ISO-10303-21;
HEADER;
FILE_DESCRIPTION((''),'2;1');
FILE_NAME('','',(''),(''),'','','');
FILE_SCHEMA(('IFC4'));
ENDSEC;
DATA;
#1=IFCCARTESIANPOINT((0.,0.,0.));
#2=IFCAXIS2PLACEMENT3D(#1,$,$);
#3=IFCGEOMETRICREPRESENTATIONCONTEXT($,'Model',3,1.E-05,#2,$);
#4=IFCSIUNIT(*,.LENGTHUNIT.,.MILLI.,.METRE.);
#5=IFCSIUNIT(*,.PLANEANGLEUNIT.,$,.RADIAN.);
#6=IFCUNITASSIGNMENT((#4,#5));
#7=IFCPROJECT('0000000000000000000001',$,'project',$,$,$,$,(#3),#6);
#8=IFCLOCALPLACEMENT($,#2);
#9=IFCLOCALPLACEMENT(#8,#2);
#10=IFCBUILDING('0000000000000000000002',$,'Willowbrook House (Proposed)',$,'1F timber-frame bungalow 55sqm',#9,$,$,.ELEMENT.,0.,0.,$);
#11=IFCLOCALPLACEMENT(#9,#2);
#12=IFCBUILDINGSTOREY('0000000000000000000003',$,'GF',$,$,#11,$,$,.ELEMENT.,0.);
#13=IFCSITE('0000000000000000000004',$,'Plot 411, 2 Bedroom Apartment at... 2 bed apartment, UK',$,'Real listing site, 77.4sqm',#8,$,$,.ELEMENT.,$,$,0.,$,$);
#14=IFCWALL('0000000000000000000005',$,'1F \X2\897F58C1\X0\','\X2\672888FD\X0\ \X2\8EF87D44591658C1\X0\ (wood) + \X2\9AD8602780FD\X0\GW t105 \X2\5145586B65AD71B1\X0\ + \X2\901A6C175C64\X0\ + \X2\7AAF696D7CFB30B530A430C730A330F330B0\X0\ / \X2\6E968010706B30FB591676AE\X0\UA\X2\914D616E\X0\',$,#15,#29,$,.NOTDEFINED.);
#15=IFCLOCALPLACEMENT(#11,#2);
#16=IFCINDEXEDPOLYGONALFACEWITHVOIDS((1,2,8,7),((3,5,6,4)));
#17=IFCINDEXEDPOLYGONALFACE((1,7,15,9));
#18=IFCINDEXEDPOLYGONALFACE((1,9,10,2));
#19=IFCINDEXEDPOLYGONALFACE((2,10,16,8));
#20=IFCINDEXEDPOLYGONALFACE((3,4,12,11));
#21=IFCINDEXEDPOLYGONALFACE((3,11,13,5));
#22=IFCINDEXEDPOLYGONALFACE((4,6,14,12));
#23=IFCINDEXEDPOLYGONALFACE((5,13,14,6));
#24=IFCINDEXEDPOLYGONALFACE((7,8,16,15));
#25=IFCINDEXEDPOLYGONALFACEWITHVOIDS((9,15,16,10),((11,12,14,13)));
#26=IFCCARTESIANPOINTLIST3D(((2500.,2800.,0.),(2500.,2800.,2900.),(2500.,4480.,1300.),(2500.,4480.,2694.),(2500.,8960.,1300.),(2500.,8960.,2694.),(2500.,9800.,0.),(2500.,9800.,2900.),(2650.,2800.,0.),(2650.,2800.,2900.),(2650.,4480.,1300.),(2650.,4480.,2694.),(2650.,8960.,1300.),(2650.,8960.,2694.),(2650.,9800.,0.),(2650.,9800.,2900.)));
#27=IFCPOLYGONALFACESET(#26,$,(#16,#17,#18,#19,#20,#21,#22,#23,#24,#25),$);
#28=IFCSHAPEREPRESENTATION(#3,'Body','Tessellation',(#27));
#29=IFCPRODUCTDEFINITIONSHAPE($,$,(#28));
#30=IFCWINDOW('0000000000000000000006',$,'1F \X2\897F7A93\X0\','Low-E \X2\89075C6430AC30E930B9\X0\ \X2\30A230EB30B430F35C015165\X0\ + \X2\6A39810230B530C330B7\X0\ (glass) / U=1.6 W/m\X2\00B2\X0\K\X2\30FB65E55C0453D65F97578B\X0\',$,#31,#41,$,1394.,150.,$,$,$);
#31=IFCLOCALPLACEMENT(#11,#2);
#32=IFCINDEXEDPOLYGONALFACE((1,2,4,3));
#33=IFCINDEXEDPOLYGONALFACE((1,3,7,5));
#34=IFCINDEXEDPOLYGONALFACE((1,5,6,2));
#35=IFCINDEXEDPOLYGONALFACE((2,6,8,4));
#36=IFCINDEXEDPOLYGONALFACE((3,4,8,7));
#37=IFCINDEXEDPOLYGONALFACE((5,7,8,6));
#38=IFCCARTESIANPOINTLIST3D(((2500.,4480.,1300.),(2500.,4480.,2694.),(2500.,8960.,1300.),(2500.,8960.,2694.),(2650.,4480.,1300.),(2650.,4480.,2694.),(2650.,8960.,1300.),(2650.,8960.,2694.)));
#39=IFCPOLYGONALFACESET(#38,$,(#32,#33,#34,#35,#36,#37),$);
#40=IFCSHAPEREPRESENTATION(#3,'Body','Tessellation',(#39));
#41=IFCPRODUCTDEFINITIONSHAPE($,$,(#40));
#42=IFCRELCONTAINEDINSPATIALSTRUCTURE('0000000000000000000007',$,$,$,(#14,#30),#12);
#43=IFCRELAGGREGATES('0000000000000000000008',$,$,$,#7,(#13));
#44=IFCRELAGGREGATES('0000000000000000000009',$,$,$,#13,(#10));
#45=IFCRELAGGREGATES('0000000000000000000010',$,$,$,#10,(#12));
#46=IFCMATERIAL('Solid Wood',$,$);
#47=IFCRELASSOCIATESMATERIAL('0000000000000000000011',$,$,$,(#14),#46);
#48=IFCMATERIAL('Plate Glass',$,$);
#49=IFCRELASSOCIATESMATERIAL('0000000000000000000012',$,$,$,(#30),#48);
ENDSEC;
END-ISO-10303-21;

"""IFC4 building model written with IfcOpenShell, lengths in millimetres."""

from ifc_helpers import new_model, si_unit, frame, frame_2d, origin, place, context, project, spatial, rectangle, extrude, material, element, fill, save


model = new_model("IFC4")

# Units and contexts
model_context = context("Model", 3, precision=1e-05, world=origin())
ifc_project = project(units=[si_unit("LENGTHUNIT", "METRE", prefix="MILLI"), si_unit("PLANEANGLEUNIT", "RADIAN")], contexts=[model_context])

# Site, building, storey
site_placement = place(None, origin())
site = spatial("IfcSite", under=ifc_project, at=site_placement, Name="Plot 411, 2 Bedroom Apartment at... 2 bed apartment, UK", ObjectType="Real listing site, 77.4sqm", CompositionType="ELEMENT", RefElevation=0.0)
building_placement = place(site_placement, origin())
building = spatial("IfcBuilding", under=site, at=building_placement, Name="Willowbrook House (Proposed)", ObjectType="1F timber-frame bungalow 55sqm", CompositionType="ELEMENT", ElevationOfRefHeight=0.0, ElevationOfTerrain=0.0)
storey_placement = place(building_placement, origin())
storey = spatial("IfcBuildingStorey", under=building, at=storey_placement, Name="GF", CompositionType="ELEMENT", Elevation=0.0)

# Shared definitions
ifc_material_1 = material(Name="Solid Wood")

# Shared definitions
ifc_material_2 = material(Name="Plate Glass")

# Wall, opening, window
wall_1_placement = place(storey_placement, frame((1250.0, 1400.0, 0.0)))
wall_1 = element("IfcWall", 1, at=wall_1_placement, inside=storey, material=ifc_material_1, Name="1F 西壁", Description="木製 軸組外壁 (wood) + 高性能GW t105 充填断熱 + 通気層 + 窯業系サイディング / 準耐火・外皮UA配慮", PredefinedType="NOTDEFINED", context=model_context, shape_type="SweptSolid", body=[
    extrude(rectangle(XDim=150.0, YDim=7000.0, at=frame_2d((75.0, 3500.0))), frame((1250.0, 1400.0, 0.0)), (0.0, 0.0, 1.0), 2900.0),
])
opening_1_placement = place(storey_placement, frame((1250.0, 2240.0, 650.0)))
opening_1 = element("IfcOpeningElement", 2, at=opening_1_placement, cuts=wall_1, PredefinedType="NOTDEFINED", context=model_context, shape_type="SweptSolid", body=[
    extrude(rectangle(XDim=150.0, YDim=4480.0, at=frame_2d((75.0, 2240.0))), frame((1250.0, 2240.0, 650.0)), (0.0, 0.0, 1.0), 1394.0),
])
window_1_placement = place(storey_placement, frame((1250.0, 2240.0, 650.0)))
window_1 = element("IfcWindow", 3, at=window_1_placement, inside=storey, material=ifc_material_2, Name="1F 西窓", Description="Low-E 複層ガラス アルゴン封入 + 樹脂サッシ (glass) / U=1.6 W/m²K・日射取得型", OverallHeight=1394.0, OverallWidth=150.0, context=model_context, shape_type="SweptSolid", body=[
    extrude(rectangle(XDim=150.0, YDim=4480.0, at=frame_2d((75.0, 2240.0))), frame((1250.0, 2240.0, 650.0)), (0.0, 0.0, 1.0), 1394.0),
])
fill(opening_1, window_1)

save(model, "model.ifc")
